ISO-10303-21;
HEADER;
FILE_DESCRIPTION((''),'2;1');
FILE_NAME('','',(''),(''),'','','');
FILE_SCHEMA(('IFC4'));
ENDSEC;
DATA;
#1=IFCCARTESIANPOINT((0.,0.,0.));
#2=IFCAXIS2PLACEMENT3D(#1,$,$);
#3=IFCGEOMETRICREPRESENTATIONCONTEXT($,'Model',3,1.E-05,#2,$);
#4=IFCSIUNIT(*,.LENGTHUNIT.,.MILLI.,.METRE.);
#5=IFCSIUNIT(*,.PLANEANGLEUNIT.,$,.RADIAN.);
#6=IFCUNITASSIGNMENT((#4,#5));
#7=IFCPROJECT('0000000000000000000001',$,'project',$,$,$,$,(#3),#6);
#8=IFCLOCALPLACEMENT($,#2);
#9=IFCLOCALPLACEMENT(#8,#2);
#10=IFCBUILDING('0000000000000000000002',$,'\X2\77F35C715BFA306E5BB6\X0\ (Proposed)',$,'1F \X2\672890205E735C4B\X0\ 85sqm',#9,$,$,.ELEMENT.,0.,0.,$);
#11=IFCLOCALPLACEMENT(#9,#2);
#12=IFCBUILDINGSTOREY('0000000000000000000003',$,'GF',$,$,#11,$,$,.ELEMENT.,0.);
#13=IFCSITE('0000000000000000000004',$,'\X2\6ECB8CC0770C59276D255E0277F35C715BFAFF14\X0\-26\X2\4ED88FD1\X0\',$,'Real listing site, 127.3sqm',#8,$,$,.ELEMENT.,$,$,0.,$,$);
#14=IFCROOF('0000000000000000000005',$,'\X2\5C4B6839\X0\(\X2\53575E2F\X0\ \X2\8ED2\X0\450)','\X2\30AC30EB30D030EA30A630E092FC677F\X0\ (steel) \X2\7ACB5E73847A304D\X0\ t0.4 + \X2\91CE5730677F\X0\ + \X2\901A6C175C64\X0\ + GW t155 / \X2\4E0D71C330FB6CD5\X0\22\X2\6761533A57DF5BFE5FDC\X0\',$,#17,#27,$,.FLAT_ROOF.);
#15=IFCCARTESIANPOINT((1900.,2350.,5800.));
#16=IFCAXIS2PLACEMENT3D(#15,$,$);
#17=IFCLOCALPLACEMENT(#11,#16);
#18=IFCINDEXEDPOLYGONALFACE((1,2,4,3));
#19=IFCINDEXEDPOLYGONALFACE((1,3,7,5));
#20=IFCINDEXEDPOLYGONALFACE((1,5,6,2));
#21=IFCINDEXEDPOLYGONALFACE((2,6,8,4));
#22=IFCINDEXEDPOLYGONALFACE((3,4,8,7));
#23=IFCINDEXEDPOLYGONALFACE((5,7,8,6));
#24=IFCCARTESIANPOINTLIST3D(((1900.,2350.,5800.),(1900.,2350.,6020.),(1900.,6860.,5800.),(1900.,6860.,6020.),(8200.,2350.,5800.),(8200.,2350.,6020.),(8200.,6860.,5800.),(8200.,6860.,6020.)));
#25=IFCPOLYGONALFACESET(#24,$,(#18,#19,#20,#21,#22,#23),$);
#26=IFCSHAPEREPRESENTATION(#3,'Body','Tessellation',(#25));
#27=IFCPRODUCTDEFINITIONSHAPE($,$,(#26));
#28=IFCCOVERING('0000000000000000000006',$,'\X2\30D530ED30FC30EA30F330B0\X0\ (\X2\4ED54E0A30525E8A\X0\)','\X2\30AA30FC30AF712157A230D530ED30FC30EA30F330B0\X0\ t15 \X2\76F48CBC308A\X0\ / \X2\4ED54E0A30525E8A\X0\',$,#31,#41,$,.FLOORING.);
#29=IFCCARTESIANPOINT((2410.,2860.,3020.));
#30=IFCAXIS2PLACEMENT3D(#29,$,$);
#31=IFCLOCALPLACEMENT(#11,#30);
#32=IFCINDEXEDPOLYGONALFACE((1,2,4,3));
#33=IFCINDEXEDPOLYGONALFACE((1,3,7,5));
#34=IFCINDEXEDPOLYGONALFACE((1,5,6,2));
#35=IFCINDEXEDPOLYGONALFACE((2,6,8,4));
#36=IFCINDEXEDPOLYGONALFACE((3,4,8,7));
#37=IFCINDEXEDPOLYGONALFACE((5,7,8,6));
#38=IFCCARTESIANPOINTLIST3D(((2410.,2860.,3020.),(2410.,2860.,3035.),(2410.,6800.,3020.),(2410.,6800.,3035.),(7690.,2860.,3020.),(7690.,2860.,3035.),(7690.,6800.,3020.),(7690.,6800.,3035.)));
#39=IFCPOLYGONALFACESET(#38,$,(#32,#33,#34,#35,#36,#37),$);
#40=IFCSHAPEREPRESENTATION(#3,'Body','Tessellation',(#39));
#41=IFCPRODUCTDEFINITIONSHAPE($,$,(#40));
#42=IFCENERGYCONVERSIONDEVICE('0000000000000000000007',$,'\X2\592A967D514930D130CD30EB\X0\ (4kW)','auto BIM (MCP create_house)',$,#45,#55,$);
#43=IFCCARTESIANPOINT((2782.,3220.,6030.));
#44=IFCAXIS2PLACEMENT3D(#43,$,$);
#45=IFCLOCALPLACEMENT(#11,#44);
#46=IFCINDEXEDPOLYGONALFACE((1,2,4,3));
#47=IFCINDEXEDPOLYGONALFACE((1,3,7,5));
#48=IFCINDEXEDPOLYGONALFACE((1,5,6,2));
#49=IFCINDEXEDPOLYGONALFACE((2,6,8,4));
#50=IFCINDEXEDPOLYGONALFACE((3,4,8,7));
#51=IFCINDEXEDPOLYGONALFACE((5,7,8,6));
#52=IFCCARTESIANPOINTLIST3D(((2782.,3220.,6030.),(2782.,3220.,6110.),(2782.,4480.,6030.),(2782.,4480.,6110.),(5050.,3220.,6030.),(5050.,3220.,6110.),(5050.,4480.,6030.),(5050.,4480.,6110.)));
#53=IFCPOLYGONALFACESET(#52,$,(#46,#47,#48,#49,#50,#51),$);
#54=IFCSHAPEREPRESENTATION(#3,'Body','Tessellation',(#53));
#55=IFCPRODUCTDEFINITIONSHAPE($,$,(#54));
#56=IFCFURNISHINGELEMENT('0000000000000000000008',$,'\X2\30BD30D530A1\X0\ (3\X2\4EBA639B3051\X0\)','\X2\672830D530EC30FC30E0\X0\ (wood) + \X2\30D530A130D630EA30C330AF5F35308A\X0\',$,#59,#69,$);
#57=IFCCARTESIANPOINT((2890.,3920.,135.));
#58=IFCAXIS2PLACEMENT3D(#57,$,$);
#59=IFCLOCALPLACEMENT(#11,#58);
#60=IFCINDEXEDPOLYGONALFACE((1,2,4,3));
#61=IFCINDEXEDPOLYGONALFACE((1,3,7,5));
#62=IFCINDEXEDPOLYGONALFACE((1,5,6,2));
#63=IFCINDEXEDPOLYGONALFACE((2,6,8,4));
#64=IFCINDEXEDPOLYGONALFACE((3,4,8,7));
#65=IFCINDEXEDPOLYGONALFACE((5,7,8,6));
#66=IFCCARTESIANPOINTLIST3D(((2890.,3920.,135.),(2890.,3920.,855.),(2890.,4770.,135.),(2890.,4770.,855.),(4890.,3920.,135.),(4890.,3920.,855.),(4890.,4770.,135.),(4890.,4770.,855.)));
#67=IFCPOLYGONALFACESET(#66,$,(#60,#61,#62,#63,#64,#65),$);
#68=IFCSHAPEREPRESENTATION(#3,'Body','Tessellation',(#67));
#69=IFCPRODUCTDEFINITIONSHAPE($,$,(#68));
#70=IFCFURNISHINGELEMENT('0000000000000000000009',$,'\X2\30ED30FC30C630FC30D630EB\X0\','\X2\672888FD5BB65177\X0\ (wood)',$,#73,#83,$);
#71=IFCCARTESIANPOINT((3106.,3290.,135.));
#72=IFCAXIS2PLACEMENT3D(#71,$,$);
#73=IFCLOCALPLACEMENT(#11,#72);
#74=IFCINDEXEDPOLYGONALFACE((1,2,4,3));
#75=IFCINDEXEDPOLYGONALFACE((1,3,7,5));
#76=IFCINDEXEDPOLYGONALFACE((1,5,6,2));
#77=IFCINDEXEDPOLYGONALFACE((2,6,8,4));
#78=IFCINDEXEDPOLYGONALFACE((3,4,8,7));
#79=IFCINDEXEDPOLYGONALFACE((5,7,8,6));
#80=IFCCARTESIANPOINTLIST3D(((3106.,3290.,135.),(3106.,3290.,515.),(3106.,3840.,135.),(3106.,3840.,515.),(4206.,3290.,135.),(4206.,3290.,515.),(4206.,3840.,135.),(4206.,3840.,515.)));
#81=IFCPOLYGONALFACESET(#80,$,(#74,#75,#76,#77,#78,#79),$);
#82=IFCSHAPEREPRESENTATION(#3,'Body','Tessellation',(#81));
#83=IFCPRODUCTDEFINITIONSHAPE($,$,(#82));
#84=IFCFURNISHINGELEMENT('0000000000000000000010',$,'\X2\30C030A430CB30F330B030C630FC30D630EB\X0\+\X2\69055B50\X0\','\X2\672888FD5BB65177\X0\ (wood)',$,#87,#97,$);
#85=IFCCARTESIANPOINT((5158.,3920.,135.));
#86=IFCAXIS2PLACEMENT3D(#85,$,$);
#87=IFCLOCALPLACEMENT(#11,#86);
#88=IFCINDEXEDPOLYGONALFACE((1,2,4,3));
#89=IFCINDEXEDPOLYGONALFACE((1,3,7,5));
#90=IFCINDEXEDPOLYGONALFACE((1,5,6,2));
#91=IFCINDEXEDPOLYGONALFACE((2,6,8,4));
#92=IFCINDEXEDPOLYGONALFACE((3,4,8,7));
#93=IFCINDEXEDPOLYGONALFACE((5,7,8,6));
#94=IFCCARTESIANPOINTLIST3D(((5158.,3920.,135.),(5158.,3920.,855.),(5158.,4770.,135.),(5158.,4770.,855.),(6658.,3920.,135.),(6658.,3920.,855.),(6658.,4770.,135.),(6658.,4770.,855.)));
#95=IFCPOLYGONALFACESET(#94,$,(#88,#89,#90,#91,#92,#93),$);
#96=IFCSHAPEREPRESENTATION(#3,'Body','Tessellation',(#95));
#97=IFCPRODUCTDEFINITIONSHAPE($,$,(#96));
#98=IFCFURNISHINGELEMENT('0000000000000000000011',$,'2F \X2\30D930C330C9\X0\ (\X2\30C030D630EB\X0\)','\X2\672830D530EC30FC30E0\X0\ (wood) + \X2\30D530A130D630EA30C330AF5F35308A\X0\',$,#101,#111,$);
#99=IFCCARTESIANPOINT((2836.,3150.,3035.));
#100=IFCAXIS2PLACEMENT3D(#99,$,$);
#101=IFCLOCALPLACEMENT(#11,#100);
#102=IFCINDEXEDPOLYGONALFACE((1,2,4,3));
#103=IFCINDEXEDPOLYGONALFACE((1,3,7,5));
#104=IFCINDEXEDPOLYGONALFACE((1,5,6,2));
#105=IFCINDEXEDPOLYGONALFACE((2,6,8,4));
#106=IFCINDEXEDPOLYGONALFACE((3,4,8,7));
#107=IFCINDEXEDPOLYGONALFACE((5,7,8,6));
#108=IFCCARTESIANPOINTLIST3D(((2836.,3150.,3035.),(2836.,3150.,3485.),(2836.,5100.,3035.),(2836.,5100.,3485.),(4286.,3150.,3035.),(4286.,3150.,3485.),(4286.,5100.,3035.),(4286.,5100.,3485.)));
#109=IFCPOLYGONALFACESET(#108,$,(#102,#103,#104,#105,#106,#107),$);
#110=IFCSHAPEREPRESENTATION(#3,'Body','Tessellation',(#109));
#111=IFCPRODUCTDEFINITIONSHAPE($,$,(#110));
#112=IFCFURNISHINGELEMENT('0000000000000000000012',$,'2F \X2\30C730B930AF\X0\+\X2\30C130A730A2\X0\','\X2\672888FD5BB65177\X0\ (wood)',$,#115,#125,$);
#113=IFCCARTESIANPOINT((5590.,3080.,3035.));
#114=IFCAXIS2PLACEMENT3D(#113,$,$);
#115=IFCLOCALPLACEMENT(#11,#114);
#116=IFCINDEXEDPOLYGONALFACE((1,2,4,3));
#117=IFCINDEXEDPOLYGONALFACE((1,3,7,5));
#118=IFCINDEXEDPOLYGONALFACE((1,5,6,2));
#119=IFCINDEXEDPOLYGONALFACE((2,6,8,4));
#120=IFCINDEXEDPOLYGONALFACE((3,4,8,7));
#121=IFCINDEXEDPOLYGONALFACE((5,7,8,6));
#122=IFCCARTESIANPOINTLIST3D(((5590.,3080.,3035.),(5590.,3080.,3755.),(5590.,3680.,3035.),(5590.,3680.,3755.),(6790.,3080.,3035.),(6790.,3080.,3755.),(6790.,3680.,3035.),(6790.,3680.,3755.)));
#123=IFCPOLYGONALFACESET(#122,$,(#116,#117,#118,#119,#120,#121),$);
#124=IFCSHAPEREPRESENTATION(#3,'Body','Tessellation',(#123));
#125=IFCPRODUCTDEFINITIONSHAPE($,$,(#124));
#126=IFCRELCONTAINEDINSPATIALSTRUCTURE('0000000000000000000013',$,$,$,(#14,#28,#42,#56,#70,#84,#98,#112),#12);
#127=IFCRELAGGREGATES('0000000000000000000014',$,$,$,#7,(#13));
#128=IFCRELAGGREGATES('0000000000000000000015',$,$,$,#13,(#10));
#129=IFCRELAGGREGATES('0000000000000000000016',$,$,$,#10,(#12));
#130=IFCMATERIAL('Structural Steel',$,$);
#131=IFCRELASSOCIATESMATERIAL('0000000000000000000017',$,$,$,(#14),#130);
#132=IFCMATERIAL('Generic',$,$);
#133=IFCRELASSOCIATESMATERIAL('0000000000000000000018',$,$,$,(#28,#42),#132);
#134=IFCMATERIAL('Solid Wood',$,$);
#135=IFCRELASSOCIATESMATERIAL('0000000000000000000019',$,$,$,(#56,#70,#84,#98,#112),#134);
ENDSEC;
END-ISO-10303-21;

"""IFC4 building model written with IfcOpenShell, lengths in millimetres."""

from ifc_helpers import new_model, si_unit, frame, frame_2d, origin, place, context, project, spatial, rectangle, extrude, material, element, save


model = new_model("IFC4")

# Units and contexts
model_context = context("Model", 3, precision=1e-05, world=origin())
ifc_project = project(units=[si_unit("LENGTHUNIT", "METRE", prefix="MILLI"), si_unit("PLANEANGLEUNIT", "RADIAN")], contexts=[model_context])

# Site, building, storey
site_placement = place(None, origin())
site = spatial("IfcSite", under=ifc_project, at=site_placement, Name="滋賀県大津市石山寺４-26付近", ObjectType="Real listing site, 127.3sqm", CompositionType="ELEMENT", RefElevation=0.0)
building_placement = place(site_placement, origin())
building = spatial("IfcBuilding", under=site, at=building_placement, Name="石山寺の家 (Proposed)", ObjectType="1F 木造平屋 85sqm", CompositionType="ELEMENT", ElevationOfRefHeight=0.0, ElevationOfTerrain=0.0)
storey_placement = place(building_placement, origin())
storey = spatial("IfcBuildingStorey", under=building, at=storey_placement, Name="GF", CompositionType="ELEMENT", Elevation=0.0)

# Shared definitions
ifc_material_1 = material(Name="Solid Wood")

# Shared definitions
ifc_material_2 = material(Name="Generic")

# Roof
ifc_material_3 = material(Name="Structural Steel")
for number, where, name in (
    (1, (1900.0, 2350.0, 5800.0), "屋根(南帯 軒450)"),
):
    element("IfcRoof", number, at=place(storey_placement, frame(where)), inside=storey, material=ifc_material_3, Name=name, Description="ガルバリウム鋼板 (steel) 立平葺き t0.4 + 野地板 + 通気層 + GW t155 / 不燃・法22条区域対応", PredefinedType="FLAT_ROOF", context=model_context, shape_type="SweptSolid", body=[
        extrude(rectangle(XDim=6300.0, YDim=4510.0, at=frame_2d((3150.0, 2255.0))), frame((1900.0, 2350.0, 5800.0)), (0.0, 0.0, 1.0), 220.0),
    ])

# Covering
covering_placement = place(storey_placement, frame((2410.0, 2860.0, 3020.0)))
element("IfcCovering", 2, at=covering_placement, inside=storey, material=ifc_material_2, Name="フローリング (仕上げ床)", Description="オーク無垢フローリング t15 直貼り / 仕上げ床", PredefinedType="FLOORING", context=model_context, shape_type="SweptSolid", body=[
    extrude(rectangle(XDim=5280.0, YDim=3940.0, at=frame_2d((2640.0, 1970.0))), frame((2410.0, 2860.0, 3020.0)), (0.0, 0.0, 1.0), 15.0),
])

# Energy conversion device
energy_conversion_device_placement = place(storey_placement, frame((2782.0, 3220.0, 6030.0)))
element("IfcEnergyConversionDevice", 3, at=energy_conversion_device_placement, inside=storey, material=ifc_material_2, Name="太陽光パネル (4kW)", Description="auto BIM (MCP create_house)", context=model_context, shape_type="SweptSolid", body=[
    extrude(rectangle(XDim=2268.0, YDim=1260.0, at=frame_2d((1134.0, 630.0))), frame((2782.0, 3220.0, 6030.0)), (0.0, 0.0, 1.0), 80.0),
])

# Furnishing elements
furnishing_1_placement = place(storey_placement, frame((2890.0, 3920.0, 135.0)))
element("IfcFurnishingElement", 4, at=furnishing_1_placement, inside=storey, material=ifc_material_1, Name="ソファ (3人掛け)", Description="木フレーム (wood) + ファブリック張り", context=model_context, shape_type="SweptSolid", body=[
    extrude(rectangle(XDim=2000.0, YDim=850.0, at=frame_2d((1000.0, 425.0))), frame((2890.0, 3920.0, 135.0)), (0.0, 0.0, 1.0), 720.0),
])
furnishing_2_placement = place(storey_placement, frame((3106.0, 3290.0, 135.0)))
element("IfcFurnishingElement", 5, at=furnishing_2_placement, inside=storey, material=ifc_material_1, Name="ローテーブル", Description="木製家具 (wood)", context=model_context, shape_type="SweptSolid", body=[
    extrude(rectangle(XDim=1100.0, YDim=550.0, at=frame_2d((550.0, 275.0))), frame((3106.0, 3290.0, 135.0)), (0.0, 0.0, 1.0), 380.0),
])
furnishing_3_placement = place(storey_placement, frame((5158.0, 3920.0, 135.0)))
element("IfcFurnishingElement", 6, at=furnishing_3_placement, inside=storey, material=ifc_material_1, Name="ダイニングテーブル+椅子", Description="木製家具 (wood)", context=model_context, shape_type="SweptSolid", body=[
    extrude(rectangle(XDim=1500.0, YDim=850.0, at=frame_2d((750.0, 425.0))), frame((5158.0, 3920.0, 135.0)), (0.0, 0.0, 1.0), 720.0),
])
furnishing_4_placement = place(storey_placement, frame((2836.0, 3150.0, 3035.0)))
element("IfcFurnishingElement", 7, at=furnishing_4_placement, inside=storey, material=ifc_material_1, Name="2F ベッド (ダブル)", Description="木フレーム (wood) + ファブリック張り", context=model_context, shape_type="SweptSolid", body=[
    extrude(rectangle(XDim=1450.0, YDim=1950.0, at=frame_2d((725.0, 975.0))), frame((2836.0, 3150.0, 3035.0)), (0.0, 0.0, 1.0), 450.0),
])
furnishing_5_placement = place(storey_placement, frame((5590.0, 3080.0, 3035.0)))
element("IfcFurnishingElement", 8, at=furnishing_5_placement, inside=storey, material=ifc_material_1, Name="2F デスク+チェア", Description="木製家具 (wood)", context=model_context, shape_type="SweptSolid", body=[
    extrude(rectangle(XDim=1200.0, YDim=600.0, at=frame_2d((600.0, 300.0))), frame((5590.0, 3080.0, 3035.0)), (0.0, 0.0, 1.0), 720.0),
])

save(model, "model.ifc")
